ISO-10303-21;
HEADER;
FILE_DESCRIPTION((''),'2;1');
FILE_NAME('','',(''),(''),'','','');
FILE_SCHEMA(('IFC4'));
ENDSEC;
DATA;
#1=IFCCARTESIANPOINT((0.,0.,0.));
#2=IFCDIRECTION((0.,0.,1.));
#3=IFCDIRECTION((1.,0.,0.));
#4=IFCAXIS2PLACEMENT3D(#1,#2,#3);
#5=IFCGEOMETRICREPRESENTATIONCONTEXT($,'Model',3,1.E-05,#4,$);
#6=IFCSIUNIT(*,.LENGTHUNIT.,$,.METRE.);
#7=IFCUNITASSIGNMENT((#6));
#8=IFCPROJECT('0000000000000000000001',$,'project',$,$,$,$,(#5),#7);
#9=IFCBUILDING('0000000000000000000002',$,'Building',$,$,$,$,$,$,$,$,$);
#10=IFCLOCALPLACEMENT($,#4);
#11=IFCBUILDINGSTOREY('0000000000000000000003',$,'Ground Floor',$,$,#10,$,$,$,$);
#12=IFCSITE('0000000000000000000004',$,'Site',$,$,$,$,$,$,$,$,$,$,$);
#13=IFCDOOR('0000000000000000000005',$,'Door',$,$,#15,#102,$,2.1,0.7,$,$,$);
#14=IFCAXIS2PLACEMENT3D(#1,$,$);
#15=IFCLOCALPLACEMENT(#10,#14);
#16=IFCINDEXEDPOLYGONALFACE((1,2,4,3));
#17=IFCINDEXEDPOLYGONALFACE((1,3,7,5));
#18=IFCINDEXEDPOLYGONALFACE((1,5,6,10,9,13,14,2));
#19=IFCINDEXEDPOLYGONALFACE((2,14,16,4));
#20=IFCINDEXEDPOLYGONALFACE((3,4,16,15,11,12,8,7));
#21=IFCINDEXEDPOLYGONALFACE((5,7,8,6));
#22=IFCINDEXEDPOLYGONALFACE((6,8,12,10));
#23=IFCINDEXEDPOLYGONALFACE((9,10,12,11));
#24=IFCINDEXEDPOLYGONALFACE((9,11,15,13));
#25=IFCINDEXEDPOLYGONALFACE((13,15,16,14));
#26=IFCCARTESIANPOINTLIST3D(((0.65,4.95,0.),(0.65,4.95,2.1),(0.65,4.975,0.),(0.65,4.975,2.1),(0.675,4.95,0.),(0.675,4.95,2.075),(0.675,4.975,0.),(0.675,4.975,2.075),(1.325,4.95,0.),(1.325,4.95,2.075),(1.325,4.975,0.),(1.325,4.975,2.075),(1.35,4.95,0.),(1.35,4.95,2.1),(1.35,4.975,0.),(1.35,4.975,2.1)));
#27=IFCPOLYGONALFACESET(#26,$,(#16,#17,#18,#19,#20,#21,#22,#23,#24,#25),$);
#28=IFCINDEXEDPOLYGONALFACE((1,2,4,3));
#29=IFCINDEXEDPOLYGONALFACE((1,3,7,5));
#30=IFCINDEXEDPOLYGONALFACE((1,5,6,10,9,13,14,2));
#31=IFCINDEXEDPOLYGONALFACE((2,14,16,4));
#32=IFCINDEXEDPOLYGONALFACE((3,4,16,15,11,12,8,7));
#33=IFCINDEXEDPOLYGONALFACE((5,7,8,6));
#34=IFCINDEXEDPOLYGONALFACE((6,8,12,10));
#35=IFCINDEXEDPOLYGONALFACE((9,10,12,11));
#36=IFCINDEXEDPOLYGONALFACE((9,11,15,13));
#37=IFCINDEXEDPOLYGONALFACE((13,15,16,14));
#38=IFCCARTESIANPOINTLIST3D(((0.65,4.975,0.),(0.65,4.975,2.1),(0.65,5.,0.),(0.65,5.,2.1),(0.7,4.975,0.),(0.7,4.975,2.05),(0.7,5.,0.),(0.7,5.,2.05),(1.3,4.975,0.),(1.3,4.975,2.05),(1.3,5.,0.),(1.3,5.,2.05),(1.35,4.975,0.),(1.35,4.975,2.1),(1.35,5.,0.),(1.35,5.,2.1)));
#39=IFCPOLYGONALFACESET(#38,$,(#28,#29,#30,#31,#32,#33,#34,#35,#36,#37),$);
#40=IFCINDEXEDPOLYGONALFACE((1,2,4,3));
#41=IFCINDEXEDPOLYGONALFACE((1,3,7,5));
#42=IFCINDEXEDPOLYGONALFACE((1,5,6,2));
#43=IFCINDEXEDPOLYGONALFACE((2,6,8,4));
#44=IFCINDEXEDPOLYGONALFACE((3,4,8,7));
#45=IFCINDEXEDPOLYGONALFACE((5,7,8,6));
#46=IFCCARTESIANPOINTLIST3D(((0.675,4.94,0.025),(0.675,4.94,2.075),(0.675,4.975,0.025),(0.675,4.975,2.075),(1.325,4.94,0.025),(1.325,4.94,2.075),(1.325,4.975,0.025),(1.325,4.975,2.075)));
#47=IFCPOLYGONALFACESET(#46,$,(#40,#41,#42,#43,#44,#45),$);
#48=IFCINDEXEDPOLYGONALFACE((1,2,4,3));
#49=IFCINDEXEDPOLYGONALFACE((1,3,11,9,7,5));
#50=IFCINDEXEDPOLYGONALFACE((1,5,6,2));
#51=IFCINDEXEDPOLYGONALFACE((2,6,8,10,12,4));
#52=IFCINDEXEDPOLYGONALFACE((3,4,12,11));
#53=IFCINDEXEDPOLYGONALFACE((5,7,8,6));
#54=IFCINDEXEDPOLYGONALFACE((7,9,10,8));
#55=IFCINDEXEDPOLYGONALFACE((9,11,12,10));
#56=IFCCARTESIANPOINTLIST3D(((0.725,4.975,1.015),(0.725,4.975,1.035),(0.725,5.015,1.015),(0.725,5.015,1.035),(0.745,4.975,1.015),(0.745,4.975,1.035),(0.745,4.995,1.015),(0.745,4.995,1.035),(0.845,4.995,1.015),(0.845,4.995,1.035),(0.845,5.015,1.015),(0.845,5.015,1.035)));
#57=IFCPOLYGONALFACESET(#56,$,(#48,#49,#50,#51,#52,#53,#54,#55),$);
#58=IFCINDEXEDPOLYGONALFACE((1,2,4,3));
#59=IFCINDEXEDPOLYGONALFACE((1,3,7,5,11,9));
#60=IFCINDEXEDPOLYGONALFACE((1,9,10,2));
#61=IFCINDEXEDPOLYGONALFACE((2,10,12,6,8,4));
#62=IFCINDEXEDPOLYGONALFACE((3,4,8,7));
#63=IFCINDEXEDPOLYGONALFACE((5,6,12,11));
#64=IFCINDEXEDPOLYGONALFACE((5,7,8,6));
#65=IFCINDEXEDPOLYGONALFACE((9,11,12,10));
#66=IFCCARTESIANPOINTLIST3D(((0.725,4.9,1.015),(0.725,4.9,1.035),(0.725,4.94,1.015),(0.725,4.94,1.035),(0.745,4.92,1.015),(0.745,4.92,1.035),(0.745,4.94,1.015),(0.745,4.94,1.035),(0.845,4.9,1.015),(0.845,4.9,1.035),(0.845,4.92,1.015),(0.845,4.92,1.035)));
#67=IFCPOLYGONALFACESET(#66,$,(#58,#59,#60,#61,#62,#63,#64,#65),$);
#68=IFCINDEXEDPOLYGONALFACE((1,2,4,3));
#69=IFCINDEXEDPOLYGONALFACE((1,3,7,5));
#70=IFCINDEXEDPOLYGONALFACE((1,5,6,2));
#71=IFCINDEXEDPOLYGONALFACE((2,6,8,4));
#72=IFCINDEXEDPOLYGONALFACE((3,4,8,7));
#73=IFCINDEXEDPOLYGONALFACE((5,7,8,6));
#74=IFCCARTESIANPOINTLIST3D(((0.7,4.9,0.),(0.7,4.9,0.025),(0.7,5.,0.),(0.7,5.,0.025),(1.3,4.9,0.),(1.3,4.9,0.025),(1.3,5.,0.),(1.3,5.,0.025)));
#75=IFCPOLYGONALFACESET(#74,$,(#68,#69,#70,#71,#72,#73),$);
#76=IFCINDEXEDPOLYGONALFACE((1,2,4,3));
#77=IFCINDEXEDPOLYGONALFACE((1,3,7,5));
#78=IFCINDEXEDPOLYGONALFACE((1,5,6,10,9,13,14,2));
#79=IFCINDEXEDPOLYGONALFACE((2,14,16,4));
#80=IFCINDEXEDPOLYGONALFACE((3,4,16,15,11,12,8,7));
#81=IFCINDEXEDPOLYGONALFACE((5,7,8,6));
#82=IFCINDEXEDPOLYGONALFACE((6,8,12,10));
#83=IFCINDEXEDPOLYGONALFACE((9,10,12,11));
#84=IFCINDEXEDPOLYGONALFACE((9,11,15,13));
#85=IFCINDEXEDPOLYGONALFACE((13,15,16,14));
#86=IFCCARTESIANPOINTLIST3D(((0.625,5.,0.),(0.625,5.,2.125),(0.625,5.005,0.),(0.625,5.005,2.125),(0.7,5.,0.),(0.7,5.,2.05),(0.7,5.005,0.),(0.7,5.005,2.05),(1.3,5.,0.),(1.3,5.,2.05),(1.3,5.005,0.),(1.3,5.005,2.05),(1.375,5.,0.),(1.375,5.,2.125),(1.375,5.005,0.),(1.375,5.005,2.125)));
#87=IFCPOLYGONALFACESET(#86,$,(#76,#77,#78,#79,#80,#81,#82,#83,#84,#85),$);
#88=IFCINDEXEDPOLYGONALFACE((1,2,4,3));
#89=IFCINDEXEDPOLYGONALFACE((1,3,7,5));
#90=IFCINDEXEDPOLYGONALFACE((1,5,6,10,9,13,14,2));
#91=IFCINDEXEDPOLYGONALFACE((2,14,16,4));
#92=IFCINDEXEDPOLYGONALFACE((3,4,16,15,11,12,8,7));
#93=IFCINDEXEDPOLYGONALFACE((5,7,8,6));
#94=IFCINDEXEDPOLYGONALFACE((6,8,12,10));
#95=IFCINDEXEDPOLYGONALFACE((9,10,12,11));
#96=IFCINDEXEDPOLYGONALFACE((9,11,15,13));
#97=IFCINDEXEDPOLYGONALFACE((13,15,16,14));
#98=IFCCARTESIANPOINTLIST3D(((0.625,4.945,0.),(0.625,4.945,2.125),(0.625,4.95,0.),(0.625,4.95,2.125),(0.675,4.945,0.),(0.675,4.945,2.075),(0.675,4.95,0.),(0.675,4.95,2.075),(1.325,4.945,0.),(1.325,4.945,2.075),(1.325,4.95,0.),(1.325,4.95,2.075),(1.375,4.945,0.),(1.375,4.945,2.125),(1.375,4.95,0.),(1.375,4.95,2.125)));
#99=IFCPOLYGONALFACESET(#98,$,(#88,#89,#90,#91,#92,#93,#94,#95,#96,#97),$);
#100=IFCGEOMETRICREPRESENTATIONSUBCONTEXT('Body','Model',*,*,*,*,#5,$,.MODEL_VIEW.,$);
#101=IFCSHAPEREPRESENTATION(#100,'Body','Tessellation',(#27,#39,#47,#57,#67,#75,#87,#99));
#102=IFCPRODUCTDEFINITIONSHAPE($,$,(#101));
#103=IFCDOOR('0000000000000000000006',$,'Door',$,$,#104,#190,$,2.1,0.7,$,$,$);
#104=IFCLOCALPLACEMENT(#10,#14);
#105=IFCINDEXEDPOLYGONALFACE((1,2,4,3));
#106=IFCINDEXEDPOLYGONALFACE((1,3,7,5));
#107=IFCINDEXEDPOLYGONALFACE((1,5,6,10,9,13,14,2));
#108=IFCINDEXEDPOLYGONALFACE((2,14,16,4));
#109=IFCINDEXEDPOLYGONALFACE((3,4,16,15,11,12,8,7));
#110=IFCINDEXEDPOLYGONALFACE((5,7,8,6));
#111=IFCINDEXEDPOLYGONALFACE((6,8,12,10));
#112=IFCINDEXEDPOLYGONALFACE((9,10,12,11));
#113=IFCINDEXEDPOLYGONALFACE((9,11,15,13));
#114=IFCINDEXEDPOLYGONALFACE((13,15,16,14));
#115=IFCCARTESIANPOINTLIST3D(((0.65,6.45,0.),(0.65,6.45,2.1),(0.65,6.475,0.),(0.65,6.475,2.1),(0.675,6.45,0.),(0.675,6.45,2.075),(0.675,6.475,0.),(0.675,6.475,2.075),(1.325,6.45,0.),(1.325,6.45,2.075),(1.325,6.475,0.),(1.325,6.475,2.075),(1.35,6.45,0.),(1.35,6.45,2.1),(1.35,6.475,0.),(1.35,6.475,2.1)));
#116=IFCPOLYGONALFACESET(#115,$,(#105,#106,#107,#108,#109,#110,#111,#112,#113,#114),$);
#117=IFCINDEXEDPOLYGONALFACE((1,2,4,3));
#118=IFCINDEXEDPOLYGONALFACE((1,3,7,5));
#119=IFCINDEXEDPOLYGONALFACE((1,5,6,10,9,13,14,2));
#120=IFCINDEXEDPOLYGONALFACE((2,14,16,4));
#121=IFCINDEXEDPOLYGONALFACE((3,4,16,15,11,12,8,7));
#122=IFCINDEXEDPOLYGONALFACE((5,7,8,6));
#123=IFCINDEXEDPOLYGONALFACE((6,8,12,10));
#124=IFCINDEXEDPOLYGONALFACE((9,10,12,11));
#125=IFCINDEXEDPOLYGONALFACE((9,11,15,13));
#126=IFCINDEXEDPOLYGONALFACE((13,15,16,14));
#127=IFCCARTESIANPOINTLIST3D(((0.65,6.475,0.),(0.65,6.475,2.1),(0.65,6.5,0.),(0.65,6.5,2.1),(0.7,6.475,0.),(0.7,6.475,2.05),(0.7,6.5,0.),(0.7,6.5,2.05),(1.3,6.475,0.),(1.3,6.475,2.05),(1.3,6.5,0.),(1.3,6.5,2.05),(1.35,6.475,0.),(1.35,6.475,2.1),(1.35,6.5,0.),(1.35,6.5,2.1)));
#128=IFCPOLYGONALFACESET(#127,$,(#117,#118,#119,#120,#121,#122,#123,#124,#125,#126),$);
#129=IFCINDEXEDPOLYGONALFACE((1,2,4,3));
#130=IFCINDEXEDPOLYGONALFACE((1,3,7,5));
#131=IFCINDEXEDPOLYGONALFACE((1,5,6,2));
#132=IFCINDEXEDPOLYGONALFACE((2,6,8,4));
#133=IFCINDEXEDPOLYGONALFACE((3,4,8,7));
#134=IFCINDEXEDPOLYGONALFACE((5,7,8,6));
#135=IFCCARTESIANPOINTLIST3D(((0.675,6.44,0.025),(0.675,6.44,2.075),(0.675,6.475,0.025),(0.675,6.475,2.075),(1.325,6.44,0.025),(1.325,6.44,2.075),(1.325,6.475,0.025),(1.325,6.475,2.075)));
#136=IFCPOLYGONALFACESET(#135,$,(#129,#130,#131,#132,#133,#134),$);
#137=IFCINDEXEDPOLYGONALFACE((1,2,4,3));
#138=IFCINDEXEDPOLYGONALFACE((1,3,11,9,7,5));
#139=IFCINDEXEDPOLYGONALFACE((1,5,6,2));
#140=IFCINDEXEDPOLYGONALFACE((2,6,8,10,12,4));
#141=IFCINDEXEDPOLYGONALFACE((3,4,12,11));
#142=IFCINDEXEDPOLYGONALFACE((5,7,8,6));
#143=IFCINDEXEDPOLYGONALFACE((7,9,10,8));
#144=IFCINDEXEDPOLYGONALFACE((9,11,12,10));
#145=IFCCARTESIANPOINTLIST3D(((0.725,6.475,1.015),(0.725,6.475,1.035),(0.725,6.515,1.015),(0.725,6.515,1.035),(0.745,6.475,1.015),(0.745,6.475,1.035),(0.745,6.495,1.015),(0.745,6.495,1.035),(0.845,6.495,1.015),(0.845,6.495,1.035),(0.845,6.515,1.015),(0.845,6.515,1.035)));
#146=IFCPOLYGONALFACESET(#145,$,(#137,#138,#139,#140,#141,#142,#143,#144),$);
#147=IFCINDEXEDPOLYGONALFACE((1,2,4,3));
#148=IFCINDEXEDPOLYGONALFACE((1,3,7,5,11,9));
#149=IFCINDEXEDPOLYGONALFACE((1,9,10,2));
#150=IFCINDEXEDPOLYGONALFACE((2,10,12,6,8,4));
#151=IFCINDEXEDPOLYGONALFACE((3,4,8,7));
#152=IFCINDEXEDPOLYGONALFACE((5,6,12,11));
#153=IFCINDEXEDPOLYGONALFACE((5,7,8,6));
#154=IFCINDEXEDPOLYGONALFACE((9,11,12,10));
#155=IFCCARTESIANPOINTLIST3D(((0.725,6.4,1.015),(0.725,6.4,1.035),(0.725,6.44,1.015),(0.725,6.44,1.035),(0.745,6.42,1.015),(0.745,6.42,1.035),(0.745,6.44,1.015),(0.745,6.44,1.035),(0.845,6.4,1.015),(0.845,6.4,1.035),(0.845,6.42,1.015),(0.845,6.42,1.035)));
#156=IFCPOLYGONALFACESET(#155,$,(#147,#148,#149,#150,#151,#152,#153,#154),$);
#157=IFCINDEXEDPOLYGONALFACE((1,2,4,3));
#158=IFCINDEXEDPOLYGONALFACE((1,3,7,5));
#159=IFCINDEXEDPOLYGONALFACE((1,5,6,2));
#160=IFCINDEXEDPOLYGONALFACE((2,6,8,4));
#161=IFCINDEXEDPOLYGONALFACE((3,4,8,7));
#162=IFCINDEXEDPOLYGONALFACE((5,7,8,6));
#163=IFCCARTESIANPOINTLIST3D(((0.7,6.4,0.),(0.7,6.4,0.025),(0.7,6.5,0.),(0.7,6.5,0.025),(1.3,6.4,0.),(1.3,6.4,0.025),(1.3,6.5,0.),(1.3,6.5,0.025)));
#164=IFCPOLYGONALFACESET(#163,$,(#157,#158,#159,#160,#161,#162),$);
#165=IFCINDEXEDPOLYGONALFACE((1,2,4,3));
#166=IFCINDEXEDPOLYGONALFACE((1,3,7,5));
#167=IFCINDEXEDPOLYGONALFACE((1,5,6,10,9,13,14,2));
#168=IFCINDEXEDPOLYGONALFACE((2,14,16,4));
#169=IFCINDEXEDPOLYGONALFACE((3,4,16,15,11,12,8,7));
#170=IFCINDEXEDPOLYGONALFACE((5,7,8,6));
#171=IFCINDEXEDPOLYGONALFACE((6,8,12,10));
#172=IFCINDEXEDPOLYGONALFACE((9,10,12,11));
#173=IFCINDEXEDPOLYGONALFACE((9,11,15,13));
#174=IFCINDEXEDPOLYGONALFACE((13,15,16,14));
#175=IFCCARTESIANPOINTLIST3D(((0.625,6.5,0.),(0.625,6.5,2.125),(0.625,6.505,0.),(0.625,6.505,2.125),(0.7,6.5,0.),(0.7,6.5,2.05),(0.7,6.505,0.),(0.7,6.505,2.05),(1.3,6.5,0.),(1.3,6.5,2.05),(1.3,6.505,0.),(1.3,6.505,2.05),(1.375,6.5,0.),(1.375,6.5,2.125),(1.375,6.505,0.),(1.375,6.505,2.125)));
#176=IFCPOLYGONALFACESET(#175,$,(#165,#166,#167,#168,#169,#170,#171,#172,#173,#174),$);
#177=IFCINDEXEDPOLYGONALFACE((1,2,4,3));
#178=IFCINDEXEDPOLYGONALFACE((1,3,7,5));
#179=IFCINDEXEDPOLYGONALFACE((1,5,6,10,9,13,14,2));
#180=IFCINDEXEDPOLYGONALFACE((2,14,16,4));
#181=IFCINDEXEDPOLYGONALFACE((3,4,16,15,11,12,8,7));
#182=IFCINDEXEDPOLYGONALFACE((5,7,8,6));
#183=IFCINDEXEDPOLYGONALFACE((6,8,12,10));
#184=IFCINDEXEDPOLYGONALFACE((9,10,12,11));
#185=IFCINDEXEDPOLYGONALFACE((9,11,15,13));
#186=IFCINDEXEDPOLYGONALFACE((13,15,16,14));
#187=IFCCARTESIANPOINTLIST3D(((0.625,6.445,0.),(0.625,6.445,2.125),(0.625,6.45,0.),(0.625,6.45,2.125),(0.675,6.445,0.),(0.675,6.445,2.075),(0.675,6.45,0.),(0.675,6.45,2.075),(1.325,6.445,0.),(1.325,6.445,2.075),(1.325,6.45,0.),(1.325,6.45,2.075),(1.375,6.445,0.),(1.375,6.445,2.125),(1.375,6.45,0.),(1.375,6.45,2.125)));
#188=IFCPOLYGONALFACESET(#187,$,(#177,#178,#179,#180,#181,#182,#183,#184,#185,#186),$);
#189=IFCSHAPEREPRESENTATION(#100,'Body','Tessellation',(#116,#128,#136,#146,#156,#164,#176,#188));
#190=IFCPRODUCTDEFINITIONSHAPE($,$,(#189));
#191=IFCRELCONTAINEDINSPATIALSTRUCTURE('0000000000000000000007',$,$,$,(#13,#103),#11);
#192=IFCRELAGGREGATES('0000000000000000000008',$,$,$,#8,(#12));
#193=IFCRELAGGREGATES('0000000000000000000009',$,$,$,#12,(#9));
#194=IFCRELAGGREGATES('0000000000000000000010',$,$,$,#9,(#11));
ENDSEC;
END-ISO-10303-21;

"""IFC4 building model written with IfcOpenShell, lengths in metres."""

from ifc_helpers import new_model, si_unit, frame, origin_with_axes, place, context, subcontext, project, spatial, line, indexed_curve, outline, extrude, element, save


model = new_model("IFC4")

# Units and contexts
model_context = context("Model", 3, precision=1e-05, world=origin_with_axes())
body_context = subcontext(model_context, "Body", "Model", "MODEL_VIEW")
ifc_project = project(units=[si_unit("LENGTHUNIT", "METRE")], contexts=[model_context])

# Site, building, storey
site = spatial("IfcSite", under=ifc_project, Name="Site")
building = spatial("IfcBuilding", under=site, Name="Building")
storey_placement = place(None, origin_with_axes())
storey = spatial("IfcBuildingStorey", under=building, at=storey_placement, Name="Ground Floor")

# Doors
door_1_placement = place(storey_placement, frame((1.35, 5.0, 0.0), z_axis=(0.0, 0.0, 1.0), x_axis=(-1.0, 0.0, 0.0)))
element("IfcDoor", 1, at=door_1_placement, inside=storey, Name="Door", OverallHeight=2.1, OverallWidth=0.7, context=body_context, shape_type="SweptSolid", body=[
    extrude(outline(indexed_curve([(0.0, 0.0), (0.0, 2.1), (0.7, 2.1), (0.7, 0.0), (0.675, 0.0), (0.675, 2.075), (0.025, 2.075), (0.025, 0.0)], segments=[line(1, 2, 3, 4, 5, 6, 7, 8, 1)])), frame((0.0, 0.025, 0.0), z_axis=(0.0, -1.0, 0.0), x_axis=(1.0, 0.0, 0.0)), (0.0, 0.0, -1.0), 0.025),
    extrude(outline(indexed_curve([(0.0, 0.0), (0.0, 2.1), (0.7, 2.1), (0.7, 0.0), (0.65, 0.0), (0.65, 2.05), (0.05, 2.05), (0.05, 0.0)], segments=[line(1, 2, 3, 4, 5, 6, 7, 8, 1)])), frame((0.0, 0.0, 0.0), z_axis=(0.0, -1.0, 0.0), x_axis=(1.0, 0.0, 0.0)), (0.0, 0.0, -1.0), 0.025),
    extrude(outline(indexed_curve([(0.0, 0.0), (0.65, 0.0), (0.65, 0.035), (0.0, 0.035)], segments=[line(1, 2, 3, 4, 1)])), frame((0.025, 0.025, 0.025), z_axis=(0.0, 0.0, 1.0), x_axis=(1.0, 0.0, 0.0)), (0.0, 0.0, 1.0), 2.05),
    extrude(outline(indexed_curve([(0.0, 0.0), (0.0, -0.04), (-0.12, -0.04), (-0.12, -0.02), (-0.02, -0.02), (-0.02, 0.0)], segments=[line(1, 2, 3, 4, 5, 6, 1)])), frame((0.625, 0.025, 1.015), z_axis=(0.0, 0.0, 1.0), x_axis=(1.0, 0.0, 0.0)), (0.0, 0.0, 1.0), 0.02),
    extrude(outline(indexed_curve([(0.0, 0.0), (0.0, 0.04), (-0.12, 0.04), (-0.12, 0.02), (-0.02, 0.02), (-0.02, 0.0)], segments=[line(1, 2, 3, 4, 5, 6, 1)])), frame((0.625, 0.06, 1.015), z_axis=(0.0, 0.0, 1.0), x_axis=(1.0, 0.0, 0.0)), (0.0, 0.0, 1.0), 0.02),
    extrude(outline(indexed_curve([(0.0, 0.0), (0.6, 0.0), (0.6, 0.1), (0.0, 0.1)], segments=[line(1, 2, 3, 4, 1)])), frame((0.05, 0.0, 0.0), z_axis=(0.0, 0.0, 1.0), x_axis=(1.0, 0.0, 0.0)), (0.0, 0.0, 1.0), 0.025),
    extrude(outline(indexed_curve([(0.0, 0.0), (0.0, 2.125), (0.75, 2.125), (0.75, 0.0), (0.675, 0.0), (0.675, 2.05), (0.075, 2.05), (0.075, 0.0)], segments=[line(1, 2, 3, 4, 5, 6, 7, 8, 1)])), frame((-0.025, -0.005, 0.0), z_axis=(0.0, -1.0, 0.0), x_axis=(1.0, 0.0, 0.0)), (0.0, 0.0, -1.0), 0.005),
    extrude(outline(indexed_curve([(0.0, 0.0), (0.0, 2.125), (0.75, 2.125), (0.75, 0.0), (0.7, 0.0), (0.7, 2.075), (0.05, 2.075), (0.05, 0.0)], segments=[line(1, 2, 3, 4, 5, 6, 7, 8, 1)])), frame((-0.025, 0.05, 0.0), z_axis=(0.0, -1.0, 0.0), x_axis=(1.0, 0.0, 0.0)), (0.0, 0.0, -1.0), 0.005),
])
door_2_placement = place(storey_placement, frame((1.35, 6.5, 0.0), z_axis=(0.0, 0.0, 1.0), x_axis=(-1.0, 0.0, 0.0)))
element("IfcDoor", 2, at=door_2_placement, inside=storey, Name="Door", OverallHeight=2.1, OverallWidth=0.7, context=body_context, shape_type="SweptSolid", body=[
    extrude(outline(indexed_curve([(0.0, 0.0), (0.0, 2.1), (0.7, 2.1), (0.7, 0.0), (0.675, 0.0), (0.675, 2.075), (0.025, 2.075), (0.025, 0.0)], segments=[line(1, 2, 3, 4, 5, 6, 7, 8, 1)])), frame((0.0, 0.025, 0.0), z_axis=(0.0, -1.0, 0.0), x_axis=(1.0, 0.0, 0.0)), (0.0, 0.0, -1.0), 0.025),
    extrude(outline(indexed_curve([(0.0, 0.0), (0.0, 2.1), (0.7, 2.1), (0.7, 0.0), (0.65, 0.0), (0.65, 2.05), (0.05, 2.05), (0.05, 0.0)], segments=[line(1, 2, 3, 4, 5, 6, 7, 8, 1)])), frame((0.0, 0.0, 0.0), z_axis=(0.0, -1.0, 0.0), x_axis=(1.0, 0.0, 0.0)), (0.0, 0.0, -1.0), 0.025),
    extrude(outline(indexed_curve([(0.0, 0.0), (0.65, 0.0), (0.65, 0.035), (0.0, 0.035)], segments=[line(1, 2, 3, 4, 1)])), frame((0.025, 0.025, 0.025), z_axis=(0.0, 0.0, 1.0), x_axis=(1.0, 0.0, 0.0)), (0.0, 0.0, 1.0), 2.05),
    extrude(outline(indexed_curve([(0.0, 0.0), (0.0, -0.04), (-0.12, -0.04), (-0.12, -0.02), (-0.02, -0.02), (-0.02, 0.0)], segments=[line(1, 2, 3, 4, 5, 6, 1)])), frame((0.625, 0.025, 1.015), z_axis=(0.0, 0.0, 1.0), x_axis=(1.0, 0.0, 0.0)), (0.0, 0.0, 1.0), 0.02),
    extrude(outline(indexed_curve([(0.0, 0.0), (0.0, 0.04), (-0.12, 0.04), (-0.12, 0.02), (-0.02, 0.02), (-0.02, 0.0)], segments=[line(1, 2, 3, 4, 5, 6, 1)])), frame((0.625, 0.06, 1.015), z_axis=(0.0, 0.0, 1.0), x_axis=(1.0, 0.0, 0.0)), (0.0, 0.0, 1.0), 0.02),
    extrude(outline(indexed_curve([(0.0, 0.0), (0.6, 0.0), (0.6, 0.1), (0.0, 0.1)], segments=[line(1, 2, 3, 4, 1)])), frame((0.05, 0.0, 0.0), z_axis=(0.0, 0.0, 1.0), x_axis=(1.0, 0.0, 0.0)), (0.0, 0.0, 1.0), 0.025),
    extrude(outline(indexed_curve([(0.0, 0.0), (0.0, 2.125), (0.75, 2.125), (0.75, 0.0), (0.675, 0.0), (0.675, 2.05), (0.075, 2.05), (0.075, 0.0)], segments=[line(1, 2, 3, 4, 5, 6, 7, 8, 1)])), frame((-0.025, -0.005, 0.0), z_axis=(0.0, -1.0, 0.0), x_axis=(1.0, 0.0, 0.0)), (0.0, 0.0, -1.0), 0.005),
    extrude(outline(indexed_curve([(0.0, 0.0), (0.0, 2.125), (0.75, 2.125), (0.75, 0.0), (0.7, 0.0), (0.7, 2.075), (0.05, 2.075), (0.05, 0.0)], segments=[line(1, 2, 3, 4, 5, 6, 7, 8, 1)])), frame((-0.025, 0.05, 0.0), z_axis=(0.0, -1.0, 0.0), x_axis=(1.0, 0.0, 0.0)), (0.0, 0.0, -1.0), 0.005),
])

save(model, "model.ifc")
